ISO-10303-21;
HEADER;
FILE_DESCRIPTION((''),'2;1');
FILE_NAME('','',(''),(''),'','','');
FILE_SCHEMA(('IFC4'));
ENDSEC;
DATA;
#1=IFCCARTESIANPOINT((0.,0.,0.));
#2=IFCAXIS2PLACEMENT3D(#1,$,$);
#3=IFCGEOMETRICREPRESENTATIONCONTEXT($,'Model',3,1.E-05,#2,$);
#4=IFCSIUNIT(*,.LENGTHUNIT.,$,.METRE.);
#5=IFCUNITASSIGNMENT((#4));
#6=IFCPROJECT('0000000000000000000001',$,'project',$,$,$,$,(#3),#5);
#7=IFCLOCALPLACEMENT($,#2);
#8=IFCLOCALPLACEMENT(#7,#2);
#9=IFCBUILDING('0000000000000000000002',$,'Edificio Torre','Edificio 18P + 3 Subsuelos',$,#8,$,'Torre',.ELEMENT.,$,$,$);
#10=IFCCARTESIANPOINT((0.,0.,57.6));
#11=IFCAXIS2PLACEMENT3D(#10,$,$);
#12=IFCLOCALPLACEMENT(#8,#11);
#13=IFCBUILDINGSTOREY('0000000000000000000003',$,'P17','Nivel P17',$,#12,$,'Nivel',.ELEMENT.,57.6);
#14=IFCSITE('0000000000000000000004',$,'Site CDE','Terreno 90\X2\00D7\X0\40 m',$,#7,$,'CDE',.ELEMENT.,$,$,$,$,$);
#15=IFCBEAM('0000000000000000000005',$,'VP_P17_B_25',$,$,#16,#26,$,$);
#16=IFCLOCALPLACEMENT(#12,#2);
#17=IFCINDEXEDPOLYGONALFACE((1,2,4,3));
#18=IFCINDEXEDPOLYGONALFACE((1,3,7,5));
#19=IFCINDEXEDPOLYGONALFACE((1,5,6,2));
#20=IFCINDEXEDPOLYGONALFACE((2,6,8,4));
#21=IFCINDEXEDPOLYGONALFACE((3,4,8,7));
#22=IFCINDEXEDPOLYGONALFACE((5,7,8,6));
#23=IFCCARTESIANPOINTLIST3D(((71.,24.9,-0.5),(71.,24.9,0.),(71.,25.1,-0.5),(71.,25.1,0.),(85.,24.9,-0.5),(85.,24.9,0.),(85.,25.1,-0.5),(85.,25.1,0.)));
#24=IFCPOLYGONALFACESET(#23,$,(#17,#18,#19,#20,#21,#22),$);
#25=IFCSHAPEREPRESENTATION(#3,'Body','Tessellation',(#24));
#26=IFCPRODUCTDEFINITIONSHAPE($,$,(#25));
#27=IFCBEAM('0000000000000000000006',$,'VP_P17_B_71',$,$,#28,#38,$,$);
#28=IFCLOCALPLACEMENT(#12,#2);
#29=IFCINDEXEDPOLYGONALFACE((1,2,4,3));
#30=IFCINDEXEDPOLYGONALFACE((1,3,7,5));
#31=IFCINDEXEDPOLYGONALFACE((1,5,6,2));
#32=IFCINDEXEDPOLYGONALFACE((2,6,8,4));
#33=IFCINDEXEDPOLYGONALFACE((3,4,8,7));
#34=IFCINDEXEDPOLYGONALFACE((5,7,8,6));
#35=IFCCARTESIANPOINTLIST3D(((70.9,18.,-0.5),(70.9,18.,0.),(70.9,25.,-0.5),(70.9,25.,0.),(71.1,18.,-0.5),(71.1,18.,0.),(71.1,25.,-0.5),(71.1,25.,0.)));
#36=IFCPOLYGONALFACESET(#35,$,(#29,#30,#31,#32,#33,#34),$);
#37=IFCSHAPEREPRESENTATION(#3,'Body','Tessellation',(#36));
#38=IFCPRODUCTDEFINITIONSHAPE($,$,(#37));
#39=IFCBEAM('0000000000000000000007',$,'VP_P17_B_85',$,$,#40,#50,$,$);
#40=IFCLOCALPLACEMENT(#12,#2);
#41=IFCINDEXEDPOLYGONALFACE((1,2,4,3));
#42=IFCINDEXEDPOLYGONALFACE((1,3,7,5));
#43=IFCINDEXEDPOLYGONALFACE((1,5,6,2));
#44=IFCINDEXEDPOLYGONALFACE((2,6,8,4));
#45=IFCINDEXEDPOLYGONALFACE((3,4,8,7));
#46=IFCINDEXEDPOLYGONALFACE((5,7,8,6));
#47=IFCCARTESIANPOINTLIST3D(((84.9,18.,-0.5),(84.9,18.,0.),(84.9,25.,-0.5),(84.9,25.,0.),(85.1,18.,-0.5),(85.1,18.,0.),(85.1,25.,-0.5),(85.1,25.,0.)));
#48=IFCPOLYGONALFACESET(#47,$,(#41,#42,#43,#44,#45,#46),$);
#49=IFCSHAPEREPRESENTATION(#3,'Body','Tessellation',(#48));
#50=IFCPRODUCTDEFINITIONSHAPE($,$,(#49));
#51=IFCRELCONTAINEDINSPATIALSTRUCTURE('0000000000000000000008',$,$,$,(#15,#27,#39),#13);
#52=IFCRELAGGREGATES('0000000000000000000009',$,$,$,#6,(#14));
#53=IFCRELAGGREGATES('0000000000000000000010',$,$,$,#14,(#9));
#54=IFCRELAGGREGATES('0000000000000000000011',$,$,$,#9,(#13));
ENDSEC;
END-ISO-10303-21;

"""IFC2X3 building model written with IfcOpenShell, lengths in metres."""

from ifc_helpers import new_model, si_unit, frame, origin, origin_2d, place, context, project, spatial, rectangle, extrude, element, save


model = new_model("IFC2X3")

# Units and contexts
model_context = context("Model", 3, precision=1e-05, world=origin())
ifc_project = project(units=[si_unit("LENGTHUNIT", "METRE")], contexts=[model_context])

# Site, building, storey
site_placement = place(None, origin())
site = spatial("IfcSite", under=ifc_project, at=site_placement, Name="Site CDE", Description="Terreno 90×40 m", LongName="CDE", CompositionType="ELEMENT")
building_placement = place(site_placement, origin())
building = spatial("IfcBuilding", under=site, at=building_placement, Name="Edificio Torre", Description="Edificio 18P + 3 Subsuelos", LongName="Torre", CompositionType="ELEMENT")
storey_placement = place(building_placement, frame((0.0, 0.0, 57.6)))
storey = spatial("IfcBuildingStorey", under=building, at=storey_placement, Name="P17", Description="Nivel P17", LongName="Nivel", CompositionType="ELEMENT", Elevation=57.6)

# Beams
for number, where, name in (
    (1, (78.0, 25.0, -0.5), "VP_P17_B_25"),
):
    element("IfcBeam", number, at=place(storey_placement, frame(where)), inside=storey, Name=name, context=model_context, shape_type="SweptSolid", body=[
        extrude(rectangle(XDim=14.0, YDim=0.2, at=origin_2d()), origin(), (0.0, 0.0, 1.0), 0.5),
    ])
for number, where, name in (
    (2, (71.0, 21.5, -0.5), "VP_P17_B_71"),
    (3, (85.0, 21.5, -0.5), "VP_P17_B_85"),
):
    element("IfcBeam", number, at=place(storey_placement, frame(where)), inside=storey, Name=name, context=model_context, shape_type="SweptSolid", body=[
        extrude(rectangle(XDim=0.2, YDim=7.0, at=origin_2d()), origin(), (0.0, 0.0, 1.0), 0.5),
    ])

save(model, "model.ifc")
